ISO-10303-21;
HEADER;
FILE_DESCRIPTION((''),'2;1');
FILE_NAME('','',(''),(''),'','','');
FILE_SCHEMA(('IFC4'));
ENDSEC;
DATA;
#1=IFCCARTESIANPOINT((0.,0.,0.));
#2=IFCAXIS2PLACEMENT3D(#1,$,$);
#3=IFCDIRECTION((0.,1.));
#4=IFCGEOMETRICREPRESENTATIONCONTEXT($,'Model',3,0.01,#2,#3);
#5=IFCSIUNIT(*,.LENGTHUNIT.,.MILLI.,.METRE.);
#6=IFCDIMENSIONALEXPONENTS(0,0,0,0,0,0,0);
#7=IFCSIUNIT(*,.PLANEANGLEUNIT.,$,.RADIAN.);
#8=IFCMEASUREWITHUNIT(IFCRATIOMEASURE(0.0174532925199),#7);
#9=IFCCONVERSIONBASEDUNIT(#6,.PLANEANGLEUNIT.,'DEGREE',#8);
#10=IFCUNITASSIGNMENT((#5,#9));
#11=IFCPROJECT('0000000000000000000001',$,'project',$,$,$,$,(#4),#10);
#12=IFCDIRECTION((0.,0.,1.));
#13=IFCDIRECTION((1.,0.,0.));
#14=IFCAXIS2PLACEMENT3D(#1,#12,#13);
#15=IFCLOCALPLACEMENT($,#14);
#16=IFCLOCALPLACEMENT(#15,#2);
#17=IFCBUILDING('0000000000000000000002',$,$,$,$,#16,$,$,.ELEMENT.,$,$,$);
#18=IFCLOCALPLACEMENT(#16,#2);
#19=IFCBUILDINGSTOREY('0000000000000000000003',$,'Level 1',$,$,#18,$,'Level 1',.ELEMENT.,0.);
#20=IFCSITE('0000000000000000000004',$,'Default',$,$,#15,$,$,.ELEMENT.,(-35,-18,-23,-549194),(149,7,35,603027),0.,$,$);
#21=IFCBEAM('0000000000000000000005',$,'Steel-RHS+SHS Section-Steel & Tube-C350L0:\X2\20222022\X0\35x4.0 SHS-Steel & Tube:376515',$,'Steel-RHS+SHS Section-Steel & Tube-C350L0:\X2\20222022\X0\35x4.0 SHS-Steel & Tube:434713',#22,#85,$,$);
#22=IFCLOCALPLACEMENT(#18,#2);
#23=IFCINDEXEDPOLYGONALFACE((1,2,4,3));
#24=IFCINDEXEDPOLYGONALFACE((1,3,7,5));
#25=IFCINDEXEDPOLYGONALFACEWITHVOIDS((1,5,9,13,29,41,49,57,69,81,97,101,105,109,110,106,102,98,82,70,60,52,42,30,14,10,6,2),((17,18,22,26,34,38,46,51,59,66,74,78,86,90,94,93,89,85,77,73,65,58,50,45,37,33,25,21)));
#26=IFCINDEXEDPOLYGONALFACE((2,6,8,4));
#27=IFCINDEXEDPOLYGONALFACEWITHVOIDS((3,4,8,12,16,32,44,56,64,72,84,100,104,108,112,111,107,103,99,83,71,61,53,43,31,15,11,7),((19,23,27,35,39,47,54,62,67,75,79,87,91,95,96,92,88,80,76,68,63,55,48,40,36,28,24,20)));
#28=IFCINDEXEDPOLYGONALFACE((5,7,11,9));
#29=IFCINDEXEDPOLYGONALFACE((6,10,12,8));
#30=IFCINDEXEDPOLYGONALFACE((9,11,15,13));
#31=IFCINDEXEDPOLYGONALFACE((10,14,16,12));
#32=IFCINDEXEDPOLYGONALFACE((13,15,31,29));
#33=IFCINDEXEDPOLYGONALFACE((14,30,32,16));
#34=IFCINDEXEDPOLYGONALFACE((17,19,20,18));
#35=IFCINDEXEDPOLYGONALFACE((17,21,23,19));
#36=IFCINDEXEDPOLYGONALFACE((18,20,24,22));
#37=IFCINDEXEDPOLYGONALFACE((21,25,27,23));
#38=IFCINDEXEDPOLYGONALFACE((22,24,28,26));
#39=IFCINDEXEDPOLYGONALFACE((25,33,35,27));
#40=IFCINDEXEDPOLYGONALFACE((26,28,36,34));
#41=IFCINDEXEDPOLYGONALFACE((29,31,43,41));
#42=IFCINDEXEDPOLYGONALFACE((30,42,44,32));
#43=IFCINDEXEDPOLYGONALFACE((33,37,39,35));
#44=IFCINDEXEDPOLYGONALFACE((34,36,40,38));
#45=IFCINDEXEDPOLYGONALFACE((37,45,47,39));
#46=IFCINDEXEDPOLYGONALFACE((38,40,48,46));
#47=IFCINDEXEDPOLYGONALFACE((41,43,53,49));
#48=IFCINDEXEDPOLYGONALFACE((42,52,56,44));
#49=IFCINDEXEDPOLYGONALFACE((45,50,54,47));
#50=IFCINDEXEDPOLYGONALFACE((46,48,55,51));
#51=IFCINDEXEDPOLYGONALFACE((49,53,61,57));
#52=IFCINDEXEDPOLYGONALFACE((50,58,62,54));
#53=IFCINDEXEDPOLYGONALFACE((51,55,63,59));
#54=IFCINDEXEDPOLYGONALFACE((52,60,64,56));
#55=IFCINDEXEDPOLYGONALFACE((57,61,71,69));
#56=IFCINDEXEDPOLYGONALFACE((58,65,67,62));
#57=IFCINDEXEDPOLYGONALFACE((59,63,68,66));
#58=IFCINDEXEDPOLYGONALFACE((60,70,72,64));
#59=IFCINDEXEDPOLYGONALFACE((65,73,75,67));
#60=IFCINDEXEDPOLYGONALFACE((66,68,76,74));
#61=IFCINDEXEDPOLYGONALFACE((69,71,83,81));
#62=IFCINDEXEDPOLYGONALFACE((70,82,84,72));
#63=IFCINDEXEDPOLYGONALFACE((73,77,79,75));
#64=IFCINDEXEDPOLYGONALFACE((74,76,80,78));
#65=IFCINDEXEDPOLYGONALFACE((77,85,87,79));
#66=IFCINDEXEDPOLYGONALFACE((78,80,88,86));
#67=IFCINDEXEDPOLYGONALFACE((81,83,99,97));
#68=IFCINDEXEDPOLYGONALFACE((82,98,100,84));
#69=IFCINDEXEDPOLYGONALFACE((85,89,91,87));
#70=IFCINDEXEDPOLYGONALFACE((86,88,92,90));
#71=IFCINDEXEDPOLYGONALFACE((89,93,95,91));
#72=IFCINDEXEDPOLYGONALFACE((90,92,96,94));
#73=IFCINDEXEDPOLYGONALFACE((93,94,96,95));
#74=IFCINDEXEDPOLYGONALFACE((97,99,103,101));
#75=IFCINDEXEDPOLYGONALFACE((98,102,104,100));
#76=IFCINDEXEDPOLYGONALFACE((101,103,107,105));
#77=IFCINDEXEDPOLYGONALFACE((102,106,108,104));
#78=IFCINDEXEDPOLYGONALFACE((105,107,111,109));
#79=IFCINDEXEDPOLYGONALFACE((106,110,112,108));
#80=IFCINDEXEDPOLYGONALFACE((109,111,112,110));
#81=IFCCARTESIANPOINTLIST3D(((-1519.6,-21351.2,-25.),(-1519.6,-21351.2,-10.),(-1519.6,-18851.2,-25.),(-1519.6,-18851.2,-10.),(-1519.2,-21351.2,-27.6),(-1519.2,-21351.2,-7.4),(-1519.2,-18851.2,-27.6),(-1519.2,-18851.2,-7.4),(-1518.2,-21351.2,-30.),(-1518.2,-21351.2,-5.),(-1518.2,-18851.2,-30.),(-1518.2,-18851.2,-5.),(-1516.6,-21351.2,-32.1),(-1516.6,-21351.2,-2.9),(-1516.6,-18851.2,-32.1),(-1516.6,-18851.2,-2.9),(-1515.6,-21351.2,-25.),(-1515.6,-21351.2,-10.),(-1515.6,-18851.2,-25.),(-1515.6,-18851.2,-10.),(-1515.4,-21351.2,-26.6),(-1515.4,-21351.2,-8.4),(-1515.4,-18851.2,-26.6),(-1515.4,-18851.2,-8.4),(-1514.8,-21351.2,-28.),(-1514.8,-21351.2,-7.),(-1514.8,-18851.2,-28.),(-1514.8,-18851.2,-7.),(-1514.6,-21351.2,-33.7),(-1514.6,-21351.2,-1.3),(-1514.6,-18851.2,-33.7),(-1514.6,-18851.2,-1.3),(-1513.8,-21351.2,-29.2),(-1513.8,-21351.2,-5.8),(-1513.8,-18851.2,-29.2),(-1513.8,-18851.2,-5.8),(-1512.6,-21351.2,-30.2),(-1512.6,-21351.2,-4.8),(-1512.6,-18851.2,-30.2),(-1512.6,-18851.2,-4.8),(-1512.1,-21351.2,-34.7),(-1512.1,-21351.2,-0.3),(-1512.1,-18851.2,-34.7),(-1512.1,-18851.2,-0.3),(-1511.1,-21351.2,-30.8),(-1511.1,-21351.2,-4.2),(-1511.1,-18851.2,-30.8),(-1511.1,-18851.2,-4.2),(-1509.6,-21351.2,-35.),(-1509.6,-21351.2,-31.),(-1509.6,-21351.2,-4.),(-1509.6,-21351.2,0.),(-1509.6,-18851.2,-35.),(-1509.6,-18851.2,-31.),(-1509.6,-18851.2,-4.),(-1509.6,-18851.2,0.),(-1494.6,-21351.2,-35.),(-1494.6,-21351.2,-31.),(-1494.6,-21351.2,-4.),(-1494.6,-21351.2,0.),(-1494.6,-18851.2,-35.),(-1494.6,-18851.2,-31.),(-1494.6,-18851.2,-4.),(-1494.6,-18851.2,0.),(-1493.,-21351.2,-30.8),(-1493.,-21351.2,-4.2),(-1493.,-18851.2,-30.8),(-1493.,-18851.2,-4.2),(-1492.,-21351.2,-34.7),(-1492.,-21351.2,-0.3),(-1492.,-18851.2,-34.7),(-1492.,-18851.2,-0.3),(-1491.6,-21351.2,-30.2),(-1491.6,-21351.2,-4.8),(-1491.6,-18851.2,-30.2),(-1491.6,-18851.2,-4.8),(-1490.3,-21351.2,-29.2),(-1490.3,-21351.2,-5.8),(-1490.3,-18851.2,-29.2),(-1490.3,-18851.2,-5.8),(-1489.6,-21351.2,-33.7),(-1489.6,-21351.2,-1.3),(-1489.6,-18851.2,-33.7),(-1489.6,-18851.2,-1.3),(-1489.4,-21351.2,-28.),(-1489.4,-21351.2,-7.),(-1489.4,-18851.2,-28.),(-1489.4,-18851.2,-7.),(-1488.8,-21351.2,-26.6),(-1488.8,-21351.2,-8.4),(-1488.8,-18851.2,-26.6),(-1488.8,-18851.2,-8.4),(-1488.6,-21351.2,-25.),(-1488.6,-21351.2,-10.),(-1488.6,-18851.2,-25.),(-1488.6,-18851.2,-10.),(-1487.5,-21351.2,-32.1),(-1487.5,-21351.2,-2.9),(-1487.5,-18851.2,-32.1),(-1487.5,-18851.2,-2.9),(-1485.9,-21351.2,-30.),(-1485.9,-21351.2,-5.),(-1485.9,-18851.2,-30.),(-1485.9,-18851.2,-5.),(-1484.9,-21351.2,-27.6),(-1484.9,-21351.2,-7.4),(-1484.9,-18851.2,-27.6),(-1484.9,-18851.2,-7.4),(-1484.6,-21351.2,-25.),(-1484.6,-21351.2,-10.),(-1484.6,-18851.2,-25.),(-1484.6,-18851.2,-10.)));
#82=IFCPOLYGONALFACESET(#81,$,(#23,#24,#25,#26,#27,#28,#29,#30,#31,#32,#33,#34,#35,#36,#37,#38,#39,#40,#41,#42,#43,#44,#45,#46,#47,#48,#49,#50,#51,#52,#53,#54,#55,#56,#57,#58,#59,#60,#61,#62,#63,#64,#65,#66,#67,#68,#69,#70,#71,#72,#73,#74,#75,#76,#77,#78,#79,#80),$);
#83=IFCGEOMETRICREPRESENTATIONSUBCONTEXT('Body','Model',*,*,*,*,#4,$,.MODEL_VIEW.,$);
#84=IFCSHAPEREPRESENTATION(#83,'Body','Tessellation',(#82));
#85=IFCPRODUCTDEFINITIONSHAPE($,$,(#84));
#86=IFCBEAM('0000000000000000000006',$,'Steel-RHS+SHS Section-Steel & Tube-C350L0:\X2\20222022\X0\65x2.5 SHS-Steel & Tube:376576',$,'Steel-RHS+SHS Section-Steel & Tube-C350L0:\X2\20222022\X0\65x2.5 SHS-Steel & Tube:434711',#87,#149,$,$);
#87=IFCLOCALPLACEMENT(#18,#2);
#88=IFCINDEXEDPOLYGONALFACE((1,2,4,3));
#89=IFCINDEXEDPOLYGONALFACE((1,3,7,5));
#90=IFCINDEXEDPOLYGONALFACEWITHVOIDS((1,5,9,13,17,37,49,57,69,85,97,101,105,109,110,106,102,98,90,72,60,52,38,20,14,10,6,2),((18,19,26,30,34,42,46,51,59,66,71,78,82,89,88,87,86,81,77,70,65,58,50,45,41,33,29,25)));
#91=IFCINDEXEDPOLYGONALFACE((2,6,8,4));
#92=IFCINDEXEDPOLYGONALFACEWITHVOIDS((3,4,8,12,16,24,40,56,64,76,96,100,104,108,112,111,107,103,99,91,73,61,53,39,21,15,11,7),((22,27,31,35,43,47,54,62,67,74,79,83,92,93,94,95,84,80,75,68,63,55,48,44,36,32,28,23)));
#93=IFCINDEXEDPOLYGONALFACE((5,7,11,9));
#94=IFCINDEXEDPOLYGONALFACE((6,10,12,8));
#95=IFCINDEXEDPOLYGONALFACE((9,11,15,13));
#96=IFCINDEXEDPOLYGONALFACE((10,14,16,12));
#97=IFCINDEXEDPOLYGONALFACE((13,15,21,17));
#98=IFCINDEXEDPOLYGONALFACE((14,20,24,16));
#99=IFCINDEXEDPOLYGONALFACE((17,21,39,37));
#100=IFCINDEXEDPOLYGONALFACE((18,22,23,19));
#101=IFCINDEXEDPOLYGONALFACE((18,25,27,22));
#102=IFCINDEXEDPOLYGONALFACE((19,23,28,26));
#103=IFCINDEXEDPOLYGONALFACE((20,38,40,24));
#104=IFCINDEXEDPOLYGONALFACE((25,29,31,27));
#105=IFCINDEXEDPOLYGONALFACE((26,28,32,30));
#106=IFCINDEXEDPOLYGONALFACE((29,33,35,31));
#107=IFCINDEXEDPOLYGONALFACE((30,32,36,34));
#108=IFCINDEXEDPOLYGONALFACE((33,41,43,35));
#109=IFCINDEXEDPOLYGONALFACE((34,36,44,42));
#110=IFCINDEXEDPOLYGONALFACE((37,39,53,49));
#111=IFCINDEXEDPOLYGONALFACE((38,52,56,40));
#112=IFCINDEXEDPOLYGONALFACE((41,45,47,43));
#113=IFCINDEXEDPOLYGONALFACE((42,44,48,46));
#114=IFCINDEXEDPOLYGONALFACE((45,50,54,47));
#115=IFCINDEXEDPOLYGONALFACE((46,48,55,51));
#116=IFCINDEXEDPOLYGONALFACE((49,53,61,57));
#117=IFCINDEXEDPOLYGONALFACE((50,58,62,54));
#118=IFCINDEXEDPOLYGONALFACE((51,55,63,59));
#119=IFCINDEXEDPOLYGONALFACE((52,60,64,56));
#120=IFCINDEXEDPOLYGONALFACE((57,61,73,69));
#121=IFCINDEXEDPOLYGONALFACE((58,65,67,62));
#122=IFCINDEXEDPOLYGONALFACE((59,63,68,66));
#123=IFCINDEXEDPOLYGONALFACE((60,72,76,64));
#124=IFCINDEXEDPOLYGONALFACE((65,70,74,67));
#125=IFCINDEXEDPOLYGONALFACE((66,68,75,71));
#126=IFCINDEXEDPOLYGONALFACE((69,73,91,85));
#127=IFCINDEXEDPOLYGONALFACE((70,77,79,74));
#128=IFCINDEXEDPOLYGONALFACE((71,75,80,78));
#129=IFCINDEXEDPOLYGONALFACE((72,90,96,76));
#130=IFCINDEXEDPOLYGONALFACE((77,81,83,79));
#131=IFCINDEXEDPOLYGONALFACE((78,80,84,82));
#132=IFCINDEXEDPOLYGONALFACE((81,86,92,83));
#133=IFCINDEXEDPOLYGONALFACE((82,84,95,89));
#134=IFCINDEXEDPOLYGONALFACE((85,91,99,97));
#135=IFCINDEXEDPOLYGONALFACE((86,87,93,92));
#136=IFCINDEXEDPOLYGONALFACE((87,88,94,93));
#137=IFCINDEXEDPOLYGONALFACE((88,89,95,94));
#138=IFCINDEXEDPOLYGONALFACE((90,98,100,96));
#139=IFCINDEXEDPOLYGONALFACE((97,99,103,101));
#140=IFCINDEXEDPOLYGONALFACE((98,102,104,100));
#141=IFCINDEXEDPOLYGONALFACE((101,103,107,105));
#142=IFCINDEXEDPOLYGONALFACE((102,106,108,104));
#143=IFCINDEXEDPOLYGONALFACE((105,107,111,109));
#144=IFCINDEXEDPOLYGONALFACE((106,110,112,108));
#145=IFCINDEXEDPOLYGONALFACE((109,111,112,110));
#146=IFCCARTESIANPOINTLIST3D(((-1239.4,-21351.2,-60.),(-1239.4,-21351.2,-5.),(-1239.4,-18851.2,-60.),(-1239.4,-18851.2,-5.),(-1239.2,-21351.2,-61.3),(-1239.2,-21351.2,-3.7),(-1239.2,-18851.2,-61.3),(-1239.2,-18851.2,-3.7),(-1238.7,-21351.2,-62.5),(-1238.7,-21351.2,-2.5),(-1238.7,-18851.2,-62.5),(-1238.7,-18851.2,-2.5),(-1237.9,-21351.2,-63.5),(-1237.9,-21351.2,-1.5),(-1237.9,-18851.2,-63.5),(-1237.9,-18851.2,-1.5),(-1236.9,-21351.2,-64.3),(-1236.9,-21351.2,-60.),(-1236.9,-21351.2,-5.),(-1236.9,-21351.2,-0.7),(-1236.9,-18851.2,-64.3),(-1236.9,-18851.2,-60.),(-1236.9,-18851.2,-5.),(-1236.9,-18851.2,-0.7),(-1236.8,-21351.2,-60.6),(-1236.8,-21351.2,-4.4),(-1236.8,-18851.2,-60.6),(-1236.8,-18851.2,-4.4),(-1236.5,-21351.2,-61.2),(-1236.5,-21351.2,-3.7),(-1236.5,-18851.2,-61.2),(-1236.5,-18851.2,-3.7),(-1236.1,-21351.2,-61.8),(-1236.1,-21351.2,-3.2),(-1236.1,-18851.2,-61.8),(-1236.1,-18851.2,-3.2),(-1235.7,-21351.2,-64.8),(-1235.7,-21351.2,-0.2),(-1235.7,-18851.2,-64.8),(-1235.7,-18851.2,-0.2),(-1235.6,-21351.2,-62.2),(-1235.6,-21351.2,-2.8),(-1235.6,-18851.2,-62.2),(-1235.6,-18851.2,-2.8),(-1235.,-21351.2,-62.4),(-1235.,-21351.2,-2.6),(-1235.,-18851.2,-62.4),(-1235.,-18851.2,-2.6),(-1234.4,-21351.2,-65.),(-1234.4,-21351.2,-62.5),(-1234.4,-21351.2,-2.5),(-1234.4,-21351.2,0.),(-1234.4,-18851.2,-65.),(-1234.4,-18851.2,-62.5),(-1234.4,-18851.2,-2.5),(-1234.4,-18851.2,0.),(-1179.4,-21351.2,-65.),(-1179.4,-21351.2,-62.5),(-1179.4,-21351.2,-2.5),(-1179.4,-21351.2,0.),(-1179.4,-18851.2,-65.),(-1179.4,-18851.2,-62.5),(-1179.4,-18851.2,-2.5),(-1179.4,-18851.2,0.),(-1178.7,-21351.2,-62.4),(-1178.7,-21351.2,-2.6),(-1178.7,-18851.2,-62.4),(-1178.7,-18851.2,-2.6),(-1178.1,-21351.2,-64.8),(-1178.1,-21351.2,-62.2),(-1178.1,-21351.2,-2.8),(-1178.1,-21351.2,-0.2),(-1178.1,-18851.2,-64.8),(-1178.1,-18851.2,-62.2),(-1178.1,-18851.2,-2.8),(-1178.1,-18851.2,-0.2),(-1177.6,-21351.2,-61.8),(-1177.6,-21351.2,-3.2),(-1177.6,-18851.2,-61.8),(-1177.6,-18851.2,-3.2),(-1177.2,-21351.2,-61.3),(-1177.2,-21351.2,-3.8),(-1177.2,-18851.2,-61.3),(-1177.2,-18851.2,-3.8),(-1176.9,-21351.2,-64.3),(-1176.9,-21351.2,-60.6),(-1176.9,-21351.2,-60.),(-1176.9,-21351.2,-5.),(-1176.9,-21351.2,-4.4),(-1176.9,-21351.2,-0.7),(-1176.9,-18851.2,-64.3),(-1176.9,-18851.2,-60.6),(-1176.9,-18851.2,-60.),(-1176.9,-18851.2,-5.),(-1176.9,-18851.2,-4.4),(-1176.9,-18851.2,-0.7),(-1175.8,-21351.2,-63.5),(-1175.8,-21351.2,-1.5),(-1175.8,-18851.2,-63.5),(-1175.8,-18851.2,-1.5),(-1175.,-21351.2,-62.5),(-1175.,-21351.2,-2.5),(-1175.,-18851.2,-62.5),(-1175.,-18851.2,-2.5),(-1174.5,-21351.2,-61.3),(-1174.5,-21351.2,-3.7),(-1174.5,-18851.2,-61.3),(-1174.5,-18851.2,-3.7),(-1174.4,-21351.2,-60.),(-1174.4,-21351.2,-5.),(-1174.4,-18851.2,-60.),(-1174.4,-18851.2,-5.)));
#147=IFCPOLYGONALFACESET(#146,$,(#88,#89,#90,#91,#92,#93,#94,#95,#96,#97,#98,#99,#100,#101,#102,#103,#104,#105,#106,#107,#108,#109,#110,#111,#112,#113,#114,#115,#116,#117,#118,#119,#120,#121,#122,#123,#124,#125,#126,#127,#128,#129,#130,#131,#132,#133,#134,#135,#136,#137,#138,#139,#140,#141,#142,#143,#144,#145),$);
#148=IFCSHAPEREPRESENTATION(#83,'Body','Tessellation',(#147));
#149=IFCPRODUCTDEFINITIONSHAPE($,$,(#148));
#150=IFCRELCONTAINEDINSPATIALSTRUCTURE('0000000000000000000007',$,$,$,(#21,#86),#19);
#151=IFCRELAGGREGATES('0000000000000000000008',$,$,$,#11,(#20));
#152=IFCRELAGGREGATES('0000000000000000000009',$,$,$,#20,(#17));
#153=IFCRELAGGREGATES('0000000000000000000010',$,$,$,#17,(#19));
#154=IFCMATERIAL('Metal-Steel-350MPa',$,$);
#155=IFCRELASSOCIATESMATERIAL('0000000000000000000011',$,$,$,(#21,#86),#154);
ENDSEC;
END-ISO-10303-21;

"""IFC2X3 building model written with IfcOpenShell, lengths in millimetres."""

from ifc_helpers import new_model, entity, si_unit, converted_unit, direction, frame, frame_2d, origin, origin_with_axes, place, context, subcontext, project, spatial, polyline, circle_curve, parameter, trimmed, segment, composite_curve, outline, extrude, material, element, save


model = new_model("IFC2X3")

# Units and contexts
model_context = context("Model", 3, precision=0.01, world=origin(), true_north=direction((0.0, 1.0)))
body_context = subcontext(model_context, "Body", "Model", "MODEL_VIEW")
ifc_project = project(units=[si_unit("LENGTHUNIT", "METRE", prefix="MILLI"), converted_unit("PLANEANGLEUNIT", "DEGREE", entity("IfcRatioMeasure", 0.0174532925199), si_unit("PLANEANGLEUNIT", "RADIAN"), dimensions=[0, 0, 0, 0, 0, 0, 0])], contexts=[model_context])

# Site, building, storey
site_placement = place(None, origin_with_axes())
site = spatial("IfcSite", under=ifc_project, at=site_placement, Name="Default", CompositionType="ELEMENT", RefLatitude=(-35, -18, -23, -549194), RefLongitude=(149, 7, 35, 603027), RefElevation=0.0)
building_placement = place(site_placement, origin())
building = spatial("IfcBuilding", under=site, at=building_placement, CompositionType="ELEMENT")
storey_placement = place(building_placement, origin())
storey = spatial("IfcBuildingStorey", under=building, at=storey_placement, Name="Level 1", LongName="Level 1", CompositionType="ELEMENT", Elevation=0.0)

# Beams
ifc_material = material(Name="Metal-Steel-350MPa")
beam_1_placement = place(storey_placement, frame((-1502.1, -18851.2, 0.0), z_axis=(0.0, 0.0, 1.0), x_axis=(0.0, -1.0, 0.0)))
element("IfcBeam", 1, at=beam_1_placement, inside=storey, material=ifc_material, Name="Steel-RHS+SHS Section-Steel & Tube-C350L0:••35x4.0 SHS-Steel & Tube:376515", ObjectType="Steel-RHS+SHS Section-Steel & Tube-C350L0:••35x4.0 SHS-Steel & Tube:434713", context=body_context, shape_type="SweptSolid", body=[
    extrude(outline(composite_curve([segment(trimmed(circle_curve(frame_2d((-7.5, -7.5), x_axis=(1.0, 0.0)), 10.0), [parameter(180.0)], [parameter(270.0)], True, "PARAMETER"), True, "CONTINUOUS"), segment(polyline([(-7.5, -17.5), (7.5, -17.5)]), True, "CONTINUOUS"), segment(trimmed(circle_curve(frame_2d((7.5, -7.5), x_axis=(1.0, 0.0)), 10.0), [parameter(270.0)], [parameter(0.0)], True, "PARAMETER"), True, "CONTINUOUS"), segment(polyline([(17.5, -7.5), (17.5, 7.5)]), True, "CONTINUOUS"), segment(trimmed(circle_curve(frame_2d((7.5, 7.5), x_axis=(1.0, 0.0)), 10.0), [parameter(0.0)], [parameter(90.0)], True, "PARAMETER"), True, "CONTINUOUS"), segment(polyline([(7.5, 17.5), (-7.5, 17.5)]), True, "CONTINUOUS"), segment(trimmed(circle_curve(frame_2d((-7.5, 7.5), x_axis=(1.0, 0.0)), 10.0), [parameter(90.0)], [parameter(180.0)], True, "PARAMETER"), True, "CONTINUOUS"), segment(polyline([(-17.5, 7.5), (-17.5, -7.5)]), True, "CONTINUOUS")], self_intersect=False), holes=[composite_curve([segment(polyline([(7.5, -13.5), (-7.5, -13.5)]), True, "CONTINUOUS"), segment(trimmed(circle_curve(frame_2d((-7.5, -7.5), x_axis=(1.0, 0.0)), 6.0), [parameter(180.0)], [parameter(270.0)], True, "PARAMETER"), False, "CONTINUOUS"), segment(polyline([(-13.5, -7.5), (-13.5, 7.5)]), True, "CONTINUOUS"), segment(trimmed(circle_curve(frame_2d((-7.5, 7.5), x_axis=(1.0, 0.0)), 6.0), [parameter(90.0)], [parameter(180.0)], True, "PARAMETER"), False, "CONTINUOUS"), segment(polyline([(-7.5, 13.5), (7.5, 13.5)]), True, "CONTINUOUS"), segment(trimmed(circle_curve(frame_2d((7.5, 7.5), x_axis=(1.0, 0.0)), 6.0), [parameter(360.0)], [parameter(90.0)], True, "PARAMETER"), False, "CONTINUOUS"), segment(polyline([(13.5, 7.5), (13.5, -7.5)]), True, "CONTINUOUS"), segment(trimmed(circle_curve(frame_2d((7.5, -7.5), x_axis=(1.0, 0.0)), 6.0), [parameter(270.0)], [parameter(0.0)], True, "PARAMETER"), False, "CONTINUOUS")], self_intersect=False)]), frame((0.0, 0.0, -17.5), z_axis=(1.0, 0.0, 0.0), x_axis=(0.0, -1.0, 0.0)), (0.0, 0.0, 1.0), 2500.0),
])
beam_2_placement = place(storey_placement, frame((-1206.9, -18851.2, 0.0), z_axis=(0.0, 0.0, 1.0), x_axis=(0.0, -1.0, 0.0)))
element("IfcBeam", 2, at=beam_2_placement, inside=storey, material=ifc_material, Name="Steel-RHS+SHS Section-Steel & Tube-C350L0:••65x2.5 SHS-Steel & Tube:376576", ObjectType="Steel-RHS+SHS Section-Steel & Tube-C350L0:••65x2.5 SHS-Steel & Tube:434711", context=body_context, shape_type="SweptSolid", body=[
    extrude(outline(composite_curve([segment(trimmed(circle_curve(frame_2d((-27.5, -27.5), x_axis=(1.0, 0.0)), 5.0), [parameter(180.0)], [parameter(270.0)], True, "PARAMETER"), True, "CONTINUOUS"), segment(polyline([(-27.5, -32.5), (27.5, -32.5)]), True, "CONTINUOUS"), segment(trimmed(circle_curve(frame_2d((27.5, -27.5), x_axis=(1.0, 0.0)), 5.0), [parameter(270.0)], [parameter(0.0)], True, "PARAMETER"), True, "CONTINUOUS"), segment(polyline([(32.5, -27.5), (32.5, 27.5)]), True, "CONTINUOUS"), segment(trimmed(circle_curve(frame_2d((27.5, 27.5), x_axis=(1.0, 0.0)), 5.0), [parameter(0.0)], [parameter(90.0)], True, "PARAMETER"), True, "CONTINUOUS"), segment(polyline([(27.5, 32.5), (-27.5, 32.5)]), True, "CONTINUOUS"), segment(trimmed(circle_curve(frame_2d((-27.5, 27.5), x_axis=(1.0, 0.0)), 5.0), [parameter(90.0)], [parameter(180.0)], True, "PARAMETER"), True, "CONTINUOUS"), segment(polyline([(-32.5, 27.5), (-32.5, -27.5)]), True, "CONTINUOUS")], self_intersect=False), holes=[composite_curve([segment(polyline([(27.5, -30.0), (-27.5, -30.0)]), True, "CONTINUOUS"), segment(trimmed(circle_curve(frame_2d((-27.5, -27.5), x_axis=(1.0, 0.0)), 2.5), [parameter(180.0)], [parameter(270.0)], True, "PARAMETER"), False, "CONTINUOUS"), segment(polyline([(-30.0, -27.5), (-30.0, 27.5)]), True, "CONTINUOUS"), segment(trimmed(circle_curve(frame_2d((-27.5, 27.5), x_axis=(1.0, 0.0)), 2.5), [parameter(90.0)], [parameter(180.0)], True, "PARAMETER"), False, "CONTINUOUS"), segment(polyline([(-27.5, 30.0), (27.5, 30.0)]), True, "CONTINUOUS"), segment(trimmed(circle_curve(frame_2d((27.5, 27.5), x_axis=(1.0, 0.0)), 2.5), [parameter(360.0)], [parameter(90.0)], True, "PARAMETER"), False, "CONTINUOUS"), segment(polyline([(30.0, 27.5), (30.0, -27.5)]), True, "CONTINUOUS"), segment(trimmed(circle_curve(frame_2d((27.5, -27.5), x_axis=(1.0, 0.0)), 2.5), [parameter(270.0)], [parameter(0.0)], True, "PARAMETER"), False, "CONTINUOUS")], self_intersect=False)]), frame((0.0, 0.0, -32.5), z_axis=(1.0, 0.0, 0.0), x_axis=(0.0, -1.0, 0.0)), (0.0, 0.0, 1.0), 2500.0),
])

save(model, "model.ifc")
